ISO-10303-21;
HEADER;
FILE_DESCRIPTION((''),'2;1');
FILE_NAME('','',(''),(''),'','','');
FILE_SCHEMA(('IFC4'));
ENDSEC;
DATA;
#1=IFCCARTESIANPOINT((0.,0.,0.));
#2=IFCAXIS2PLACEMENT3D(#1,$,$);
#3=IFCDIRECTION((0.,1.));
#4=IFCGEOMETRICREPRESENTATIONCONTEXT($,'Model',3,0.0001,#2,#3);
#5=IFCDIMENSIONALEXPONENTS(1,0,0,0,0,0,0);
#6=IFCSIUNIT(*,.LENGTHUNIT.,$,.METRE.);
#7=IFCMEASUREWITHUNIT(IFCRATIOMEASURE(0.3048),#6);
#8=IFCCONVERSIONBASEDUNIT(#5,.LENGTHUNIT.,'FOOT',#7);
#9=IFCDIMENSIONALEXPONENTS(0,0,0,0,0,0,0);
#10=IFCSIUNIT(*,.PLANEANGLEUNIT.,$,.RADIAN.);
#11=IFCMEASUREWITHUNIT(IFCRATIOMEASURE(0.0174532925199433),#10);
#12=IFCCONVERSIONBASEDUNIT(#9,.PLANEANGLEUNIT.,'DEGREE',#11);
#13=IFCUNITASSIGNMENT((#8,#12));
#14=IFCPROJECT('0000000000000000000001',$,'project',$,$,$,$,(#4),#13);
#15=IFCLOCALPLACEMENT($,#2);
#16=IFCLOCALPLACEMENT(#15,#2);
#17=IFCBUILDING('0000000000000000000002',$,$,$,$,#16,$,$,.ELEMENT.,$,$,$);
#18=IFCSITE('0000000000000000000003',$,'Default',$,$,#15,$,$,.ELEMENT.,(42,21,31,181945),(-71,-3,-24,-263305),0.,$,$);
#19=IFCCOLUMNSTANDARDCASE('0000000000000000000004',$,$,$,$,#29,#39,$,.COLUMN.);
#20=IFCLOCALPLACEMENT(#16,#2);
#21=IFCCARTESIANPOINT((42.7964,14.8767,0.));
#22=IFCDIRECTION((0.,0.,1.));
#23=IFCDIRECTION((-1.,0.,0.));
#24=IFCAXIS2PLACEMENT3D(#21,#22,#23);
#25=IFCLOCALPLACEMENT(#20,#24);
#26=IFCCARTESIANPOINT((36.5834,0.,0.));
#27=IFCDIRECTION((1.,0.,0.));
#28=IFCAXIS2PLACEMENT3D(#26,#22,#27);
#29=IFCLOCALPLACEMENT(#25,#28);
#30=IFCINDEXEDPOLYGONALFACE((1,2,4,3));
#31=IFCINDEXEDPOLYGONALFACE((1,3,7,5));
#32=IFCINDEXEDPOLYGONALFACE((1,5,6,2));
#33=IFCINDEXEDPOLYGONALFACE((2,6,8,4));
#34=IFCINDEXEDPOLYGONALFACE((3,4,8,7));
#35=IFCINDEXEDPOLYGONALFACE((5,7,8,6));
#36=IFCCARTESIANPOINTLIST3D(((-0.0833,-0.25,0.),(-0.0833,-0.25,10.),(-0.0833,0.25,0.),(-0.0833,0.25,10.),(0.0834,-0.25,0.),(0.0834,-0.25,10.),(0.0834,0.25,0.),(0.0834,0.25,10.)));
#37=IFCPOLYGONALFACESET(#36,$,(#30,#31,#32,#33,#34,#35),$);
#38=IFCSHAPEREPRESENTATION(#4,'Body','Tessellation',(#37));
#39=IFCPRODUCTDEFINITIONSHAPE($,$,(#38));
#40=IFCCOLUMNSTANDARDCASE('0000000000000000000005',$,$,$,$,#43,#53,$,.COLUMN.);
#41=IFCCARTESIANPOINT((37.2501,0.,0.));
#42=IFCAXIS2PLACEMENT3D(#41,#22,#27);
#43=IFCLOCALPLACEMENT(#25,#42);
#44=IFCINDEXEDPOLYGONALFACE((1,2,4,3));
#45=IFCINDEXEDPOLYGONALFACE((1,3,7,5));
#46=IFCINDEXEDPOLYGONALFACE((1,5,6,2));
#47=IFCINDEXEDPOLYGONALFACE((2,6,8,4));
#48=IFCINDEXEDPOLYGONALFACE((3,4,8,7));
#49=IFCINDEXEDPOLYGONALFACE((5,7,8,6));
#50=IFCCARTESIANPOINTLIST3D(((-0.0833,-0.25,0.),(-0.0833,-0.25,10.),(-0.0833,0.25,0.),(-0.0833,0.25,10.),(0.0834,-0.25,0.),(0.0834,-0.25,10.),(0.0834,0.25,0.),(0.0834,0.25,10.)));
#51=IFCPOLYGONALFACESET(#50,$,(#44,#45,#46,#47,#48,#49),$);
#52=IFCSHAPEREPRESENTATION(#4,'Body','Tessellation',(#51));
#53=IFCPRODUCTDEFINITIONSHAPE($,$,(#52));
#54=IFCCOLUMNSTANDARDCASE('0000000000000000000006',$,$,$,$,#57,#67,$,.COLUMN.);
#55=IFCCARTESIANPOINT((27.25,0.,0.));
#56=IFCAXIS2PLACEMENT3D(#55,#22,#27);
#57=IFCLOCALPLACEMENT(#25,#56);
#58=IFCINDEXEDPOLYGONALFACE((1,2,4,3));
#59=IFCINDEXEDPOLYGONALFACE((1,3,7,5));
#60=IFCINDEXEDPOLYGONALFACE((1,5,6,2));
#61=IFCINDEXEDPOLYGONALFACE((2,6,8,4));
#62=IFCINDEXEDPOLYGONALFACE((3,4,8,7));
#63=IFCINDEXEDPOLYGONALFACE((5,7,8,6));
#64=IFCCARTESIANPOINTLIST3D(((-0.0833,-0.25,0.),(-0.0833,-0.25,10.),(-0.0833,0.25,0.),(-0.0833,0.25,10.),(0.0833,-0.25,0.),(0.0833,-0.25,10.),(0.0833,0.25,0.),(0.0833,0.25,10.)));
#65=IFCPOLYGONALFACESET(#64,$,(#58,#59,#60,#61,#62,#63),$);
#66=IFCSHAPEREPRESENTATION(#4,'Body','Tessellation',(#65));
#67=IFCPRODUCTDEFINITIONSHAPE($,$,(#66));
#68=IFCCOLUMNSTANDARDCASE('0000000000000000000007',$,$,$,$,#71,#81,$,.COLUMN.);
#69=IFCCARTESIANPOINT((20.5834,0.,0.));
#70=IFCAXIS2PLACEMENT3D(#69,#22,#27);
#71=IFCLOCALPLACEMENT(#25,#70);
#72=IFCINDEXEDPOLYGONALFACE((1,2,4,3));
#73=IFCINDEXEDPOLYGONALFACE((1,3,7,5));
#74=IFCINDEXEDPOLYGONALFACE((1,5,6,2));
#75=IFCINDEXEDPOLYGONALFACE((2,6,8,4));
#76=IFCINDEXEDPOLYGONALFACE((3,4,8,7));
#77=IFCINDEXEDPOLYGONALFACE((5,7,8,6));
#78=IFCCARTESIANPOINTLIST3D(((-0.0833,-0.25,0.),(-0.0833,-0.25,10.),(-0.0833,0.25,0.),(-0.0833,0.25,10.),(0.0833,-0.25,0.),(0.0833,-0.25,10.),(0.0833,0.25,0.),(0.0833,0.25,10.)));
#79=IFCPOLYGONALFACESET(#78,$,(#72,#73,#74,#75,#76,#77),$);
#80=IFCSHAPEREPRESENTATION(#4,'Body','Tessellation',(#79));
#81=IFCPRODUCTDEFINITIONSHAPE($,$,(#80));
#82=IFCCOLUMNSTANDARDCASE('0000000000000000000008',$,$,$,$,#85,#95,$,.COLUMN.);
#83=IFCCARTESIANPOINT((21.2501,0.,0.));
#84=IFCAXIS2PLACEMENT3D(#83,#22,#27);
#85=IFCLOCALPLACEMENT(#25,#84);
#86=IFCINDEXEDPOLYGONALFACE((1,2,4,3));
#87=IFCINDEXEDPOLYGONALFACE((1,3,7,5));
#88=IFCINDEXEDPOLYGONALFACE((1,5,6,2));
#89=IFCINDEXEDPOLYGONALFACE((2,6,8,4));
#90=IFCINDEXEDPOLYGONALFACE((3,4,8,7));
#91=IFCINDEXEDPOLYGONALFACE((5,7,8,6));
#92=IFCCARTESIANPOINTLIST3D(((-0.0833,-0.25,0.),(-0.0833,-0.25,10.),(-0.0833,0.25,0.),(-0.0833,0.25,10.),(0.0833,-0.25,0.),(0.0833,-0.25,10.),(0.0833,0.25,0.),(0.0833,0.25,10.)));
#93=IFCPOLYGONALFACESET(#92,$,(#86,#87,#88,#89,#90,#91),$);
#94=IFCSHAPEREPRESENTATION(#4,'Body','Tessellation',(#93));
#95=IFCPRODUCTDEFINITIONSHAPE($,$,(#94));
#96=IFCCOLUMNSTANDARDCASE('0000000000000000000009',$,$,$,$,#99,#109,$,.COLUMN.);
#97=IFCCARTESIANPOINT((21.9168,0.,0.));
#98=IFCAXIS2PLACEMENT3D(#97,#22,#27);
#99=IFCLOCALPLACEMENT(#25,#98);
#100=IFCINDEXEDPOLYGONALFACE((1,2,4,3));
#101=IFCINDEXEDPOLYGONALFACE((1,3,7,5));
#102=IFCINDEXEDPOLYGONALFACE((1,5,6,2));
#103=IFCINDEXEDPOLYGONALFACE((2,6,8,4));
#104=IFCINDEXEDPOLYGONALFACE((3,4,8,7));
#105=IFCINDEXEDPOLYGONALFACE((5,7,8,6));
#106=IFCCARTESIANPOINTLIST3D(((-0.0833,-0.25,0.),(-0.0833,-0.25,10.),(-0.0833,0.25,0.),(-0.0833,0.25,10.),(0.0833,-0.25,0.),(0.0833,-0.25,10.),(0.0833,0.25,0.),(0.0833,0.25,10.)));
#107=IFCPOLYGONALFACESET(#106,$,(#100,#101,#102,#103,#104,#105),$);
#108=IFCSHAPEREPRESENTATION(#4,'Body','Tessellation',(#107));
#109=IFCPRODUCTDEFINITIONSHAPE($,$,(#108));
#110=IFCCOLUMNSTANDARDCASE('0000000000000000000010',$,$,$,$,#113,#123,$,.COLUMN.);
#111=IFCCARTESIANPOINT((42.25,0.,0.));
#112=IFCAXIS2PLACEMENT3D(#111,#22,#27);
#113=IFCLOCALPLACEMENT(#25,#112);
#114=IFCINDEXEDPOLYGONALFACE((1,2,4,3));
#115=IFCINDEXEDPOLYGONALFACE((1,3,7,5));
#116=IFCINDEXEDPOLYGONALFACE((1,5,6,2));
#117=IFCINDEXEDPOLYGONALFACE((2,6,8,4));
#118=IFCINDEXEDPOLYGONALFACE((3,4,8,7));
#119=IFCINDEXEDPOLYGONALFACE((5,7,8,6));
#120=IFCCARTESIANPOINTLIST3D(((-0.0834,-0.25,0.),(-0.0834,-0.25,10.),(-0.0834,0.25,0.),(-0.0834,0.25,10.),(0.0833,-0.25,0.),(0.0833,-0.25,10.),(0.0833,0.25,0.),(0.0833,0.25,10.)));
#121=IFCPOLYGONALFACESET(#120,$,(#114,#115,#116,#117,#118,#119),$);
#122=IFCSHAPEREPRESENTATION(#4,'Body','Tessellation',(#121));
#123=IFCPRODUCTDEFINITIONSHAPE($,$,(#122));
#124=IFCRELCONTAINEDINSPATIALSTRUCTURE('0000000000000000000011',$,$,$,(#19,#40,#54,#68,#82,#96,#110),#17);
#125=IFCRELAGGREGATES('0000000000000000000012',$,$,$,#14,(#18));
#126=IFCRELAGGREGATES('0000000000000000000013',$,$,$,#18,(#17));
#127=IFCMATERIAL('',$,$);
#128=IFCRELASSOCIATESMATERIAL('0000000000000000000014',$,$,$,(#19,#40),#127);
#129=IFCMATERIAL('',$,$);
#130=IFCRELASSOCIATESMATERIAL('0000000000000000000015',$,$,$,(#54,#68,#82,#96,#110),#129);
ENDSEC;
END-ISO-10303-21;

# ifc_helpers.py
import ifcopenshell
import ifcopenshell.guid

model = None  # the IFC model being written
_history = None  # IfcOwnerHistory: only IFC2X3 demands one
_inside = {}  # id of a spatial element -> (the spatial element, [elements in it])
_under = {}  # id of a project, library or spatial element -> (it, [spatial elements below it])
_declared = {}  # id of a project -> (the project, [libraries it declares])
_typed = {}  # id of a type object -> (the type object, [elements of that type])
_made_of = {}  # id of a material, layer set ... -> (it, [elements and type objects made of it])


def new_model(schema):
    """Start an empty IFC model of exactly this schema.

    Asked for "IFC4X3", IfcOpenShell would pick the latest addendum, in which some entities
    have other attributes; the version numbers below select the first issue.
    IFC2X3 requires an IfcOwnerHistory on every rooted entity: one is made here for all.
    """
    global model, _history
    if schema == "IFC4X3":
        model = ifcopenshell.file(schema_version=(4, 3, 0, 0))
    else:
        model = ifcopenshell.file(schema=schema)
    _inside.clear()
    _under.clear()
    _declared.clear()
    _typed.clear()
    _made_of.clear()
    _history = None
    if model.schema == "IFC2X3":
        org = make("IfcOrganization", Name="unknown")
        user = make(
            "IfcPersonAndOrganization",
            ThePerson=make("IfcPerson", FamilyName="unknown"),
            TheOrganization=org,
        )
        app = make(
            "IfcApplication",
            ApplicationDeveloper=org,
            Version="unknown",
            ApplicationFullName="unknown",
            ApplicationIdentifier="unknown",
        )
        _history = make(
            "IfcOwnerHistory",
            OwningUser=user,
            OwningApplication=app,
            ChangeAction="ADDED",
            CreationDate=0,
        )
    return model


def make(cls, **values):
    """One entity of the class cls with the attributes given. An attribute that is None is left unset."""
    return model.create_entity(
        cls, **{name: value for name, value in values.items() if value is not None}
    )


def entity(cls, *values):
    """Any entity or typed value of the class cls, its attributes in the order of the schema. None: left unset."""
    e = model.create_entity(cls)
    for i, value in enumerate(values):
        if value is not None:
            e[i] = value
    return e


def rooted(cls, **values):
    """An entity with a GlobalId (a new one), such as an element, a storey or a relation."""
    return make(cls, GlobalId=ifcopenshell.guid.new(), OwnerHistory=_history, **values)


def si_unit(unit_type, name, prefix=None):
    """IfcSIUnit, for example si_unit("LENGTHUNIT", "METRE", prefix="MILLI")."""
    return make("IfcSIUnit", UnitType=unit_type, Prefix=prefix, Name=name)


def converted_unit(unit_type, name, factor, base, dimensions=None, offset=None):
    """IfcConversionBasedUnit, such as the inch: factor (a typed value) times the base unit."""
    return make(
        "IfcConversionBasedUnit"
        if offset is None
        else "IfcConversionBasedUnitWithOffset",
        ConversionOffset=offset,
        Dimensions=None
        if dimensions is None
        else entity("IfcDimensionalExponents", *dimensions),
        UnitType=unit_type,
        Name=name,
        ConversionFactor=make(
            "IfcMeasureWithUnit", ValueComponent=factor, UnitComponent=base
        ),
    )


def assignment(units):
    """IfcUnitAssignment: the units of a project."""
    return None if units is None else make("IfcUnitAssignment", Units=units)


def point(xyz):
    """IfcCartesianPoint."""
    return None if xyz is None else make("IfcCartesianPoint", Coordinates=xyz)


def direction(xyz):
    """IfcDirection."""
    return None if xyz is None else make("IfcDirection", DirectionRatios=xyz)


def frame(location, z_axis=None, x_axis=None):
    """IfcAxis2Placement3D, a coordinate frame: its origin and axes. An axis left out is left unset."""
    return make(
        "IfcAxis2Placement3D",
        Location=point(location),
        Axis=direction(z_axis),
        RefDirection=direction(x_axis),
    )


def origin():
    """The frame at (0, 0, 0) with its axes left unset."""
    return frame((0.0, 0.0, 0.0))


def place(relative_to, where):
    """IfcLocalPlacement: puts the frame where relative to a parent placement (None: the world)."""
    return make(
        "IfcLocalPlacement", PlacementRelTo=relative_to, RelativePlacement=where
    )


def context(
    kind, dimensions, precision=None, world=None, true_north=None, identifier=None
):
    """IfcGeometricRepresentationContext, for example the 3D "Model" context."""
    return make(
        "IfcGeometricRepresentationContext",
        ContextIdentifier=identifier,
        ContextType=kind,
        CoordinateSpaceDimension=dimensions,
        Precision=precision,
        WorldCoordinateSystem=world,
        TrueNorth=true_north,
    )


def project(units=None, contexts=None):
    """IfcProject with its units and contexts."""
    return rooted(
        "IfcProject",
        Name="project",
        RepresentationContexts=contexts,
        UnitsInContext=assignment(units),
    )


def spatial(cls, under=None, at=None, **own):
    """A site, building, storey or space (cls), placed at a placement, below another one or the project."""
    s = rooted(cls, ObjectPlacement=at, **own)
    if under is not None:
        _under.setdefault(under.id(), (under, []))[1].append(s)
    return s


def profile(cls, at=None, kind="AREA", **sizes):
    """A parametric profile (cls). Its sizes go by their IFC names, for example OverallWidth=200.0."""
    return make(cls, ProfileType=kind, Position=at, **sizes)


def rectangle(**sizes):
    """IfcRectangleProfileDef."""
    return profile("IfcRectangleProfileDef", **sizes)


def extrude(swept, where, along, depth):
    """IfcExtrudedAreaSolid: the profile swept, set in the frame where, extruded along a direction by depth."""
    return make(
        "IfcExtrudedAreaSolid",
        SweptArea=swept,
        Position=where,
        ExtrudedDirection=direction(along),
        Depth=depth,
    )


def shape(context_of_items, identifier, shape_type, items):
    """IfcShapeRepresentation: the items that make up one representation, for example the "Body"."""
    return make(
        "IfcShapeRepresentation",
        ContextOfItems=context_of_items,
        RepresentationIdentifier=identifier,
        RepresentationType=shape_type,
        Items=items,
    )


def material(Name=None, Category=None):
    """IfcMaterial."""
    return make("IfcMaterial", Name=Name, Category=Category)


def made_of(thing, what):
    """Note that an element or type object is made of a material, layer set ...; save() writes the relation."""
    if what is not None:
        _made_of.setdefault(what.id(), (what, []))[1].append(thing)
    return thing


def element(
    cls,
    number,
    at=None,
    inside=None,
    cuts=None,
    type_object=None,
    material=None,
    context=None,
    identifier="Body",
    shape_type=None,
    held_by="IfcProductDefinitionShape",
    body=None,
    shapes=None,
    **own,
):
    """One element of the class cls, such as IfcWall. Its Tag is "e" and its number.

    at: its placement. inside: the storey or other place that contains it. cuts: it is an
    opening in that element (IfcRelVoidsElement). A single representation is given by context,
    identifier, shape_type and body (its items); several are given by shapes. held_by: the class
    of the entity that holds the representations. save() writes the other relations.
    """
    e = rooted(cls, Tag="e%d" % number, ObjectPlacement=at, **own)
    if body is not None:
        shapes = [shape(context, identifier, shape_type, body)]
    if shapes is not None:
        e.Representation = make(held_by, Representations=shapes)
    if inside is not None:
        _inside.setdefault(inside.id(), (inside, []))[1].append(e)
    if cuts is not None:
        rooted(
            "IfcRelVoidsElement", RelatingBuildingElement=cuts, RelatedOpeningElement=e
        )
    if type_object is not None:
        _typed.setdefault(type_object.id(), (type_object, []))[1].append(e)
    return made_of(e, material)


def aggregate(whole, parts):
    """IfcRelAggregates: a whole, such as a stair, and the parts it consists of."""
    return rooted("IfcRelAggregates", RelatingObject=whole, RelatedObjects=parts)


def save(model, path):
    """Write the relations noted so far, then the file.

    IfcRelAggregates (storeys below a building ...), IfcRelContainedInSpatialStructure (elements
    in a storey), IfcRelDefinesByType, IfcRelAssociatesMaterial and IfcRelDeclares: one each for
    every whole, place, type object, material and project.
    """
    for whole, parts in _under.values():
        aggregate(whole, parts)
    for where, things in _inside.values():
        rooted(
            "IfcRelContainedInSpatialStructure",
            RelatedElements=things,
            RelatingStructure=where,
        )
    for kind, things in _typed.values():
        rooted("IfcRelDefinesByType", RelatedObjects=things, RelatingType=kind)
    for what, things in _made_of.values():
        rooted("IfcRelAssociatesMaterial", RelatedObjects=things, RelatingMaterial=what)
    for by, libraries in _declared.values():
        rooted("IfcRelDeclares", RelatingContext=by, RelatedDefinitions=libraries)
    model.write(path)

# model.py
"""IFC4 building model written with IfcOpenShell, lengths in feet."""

from ifc_helpers import new_model, entity, si_unit, converted_unit, direction, frame, origin, place, context, project, spatial, rectangle, extrude, material, element, save


model = new_model("IFC4")

# Units and contexts
model_context = context("Model", 3, precision=0.0001, world=origin(), true_north=direction((0.0, 1.0)))
ifc_project = project(units=[converted_unit("LENGTHUNIT", "FOOT", entity("IfcRatioMeasure", 0.3048), si_unit("LENGTHUNIT", "METRE"), dimensions=[1, 0, 0, 0, 0, 0, 0]), converted_unit("PLANEANGLEUNIT", "DEGREE", entity("IfcRatioMeasure", 0.0174532925199433), si_unit("PLANEANGLEUNIT", "RADIAN"), dimensions=[0, 0, 0, 0, 0, 0, 0])], contexts=[model_context])

# Site, building
site_placement = place(None, origin())
site = spatial("IfcSite", under=ifc_project, at=site_placement, Name="Default", CompositionType="ELEMENT", RefLatitude=(42, 21, 31, 181945), RefLongitude=(-71, -3, -24, -263305), RefElevation=0.0)
building_placement = place(site_placement, origin())
building = spatial("IfcBuilding", under=site, at=building_placement, CompositionType="ELEMENT")

# Columns
placement_1 = place(building_placement, origin())
ifc_material_1 = material(Name="")
ifc_material_2 = material(Name="")
placement_2 = place(placement_1, frame((42.7964, 14.8767, 0.0), z_axis=(0.0, 0.0, 1.0), x_axis=(-1.0, 0.0, 0.0)))
for number, where, z_axis, x_axis in (
    (1, (36.5834, 0.0, 0.0), (0.0, 0.0, 1.0), (1.0, 0.0, 0.0)),
    (2, (37.2501, 0.0, 0.0), (0.0, 0.0, 1.0), (1.0, 0.0, 0.0)),
):
    element("IfcColumnStandardCase", number, at=place(placement_2, frame(where, z_axis=z_axis, x_axis=x_axis)), inside=building, material=ifc_material_1, PredefinedType="COLUMN", context=model_context, shape_type="SweptSolid", body=[
        extrude(rectangle(XDim=0.1667, YDim=0.5), origin(), (0.0, 0.0, 1.0), 10.0),
    ])
for number, where, z_axis, x_axis in (
    (3, (27.25, 0.0, 0.0), (0.0, 0.0, 1.0), (1.0, 0.0, 0.0)),
    (4, (20.5834, 0.0, 0.0), (0.0, 0.0, 1.0), (1.0, 0.0, 0.0)),
    (5, (21.2501, 0.0, 0.0), (0.0, 0.0, 1.0), (1.0, 0.0, 0.0)),
    (6, (21.9168, 0.0, 0.0), (0.0, 0.0, 1.0), (1.0, 0.0, 0.0)),
    (7, (42.25, 0.0, 0.0), (0.0, 0.0, 1.0), (1.0, 0.0, 0.0)),
):
    element("IfcColumnStandardCase", number, at=place(placement_2, frame(where, z_axis=z_axis, x_axis=x_axis)), inside=building, material=ifc_material_2, PredefinedType="COLUMN", context=model_context, shape_type="SweptSolid", body=[
        extrude(rectangle(XDim=0.1667, YDim=0.5), origin(), (0.0, 0.0, 1.0), 10.0),
    ])

save(model, "model.ifc")
